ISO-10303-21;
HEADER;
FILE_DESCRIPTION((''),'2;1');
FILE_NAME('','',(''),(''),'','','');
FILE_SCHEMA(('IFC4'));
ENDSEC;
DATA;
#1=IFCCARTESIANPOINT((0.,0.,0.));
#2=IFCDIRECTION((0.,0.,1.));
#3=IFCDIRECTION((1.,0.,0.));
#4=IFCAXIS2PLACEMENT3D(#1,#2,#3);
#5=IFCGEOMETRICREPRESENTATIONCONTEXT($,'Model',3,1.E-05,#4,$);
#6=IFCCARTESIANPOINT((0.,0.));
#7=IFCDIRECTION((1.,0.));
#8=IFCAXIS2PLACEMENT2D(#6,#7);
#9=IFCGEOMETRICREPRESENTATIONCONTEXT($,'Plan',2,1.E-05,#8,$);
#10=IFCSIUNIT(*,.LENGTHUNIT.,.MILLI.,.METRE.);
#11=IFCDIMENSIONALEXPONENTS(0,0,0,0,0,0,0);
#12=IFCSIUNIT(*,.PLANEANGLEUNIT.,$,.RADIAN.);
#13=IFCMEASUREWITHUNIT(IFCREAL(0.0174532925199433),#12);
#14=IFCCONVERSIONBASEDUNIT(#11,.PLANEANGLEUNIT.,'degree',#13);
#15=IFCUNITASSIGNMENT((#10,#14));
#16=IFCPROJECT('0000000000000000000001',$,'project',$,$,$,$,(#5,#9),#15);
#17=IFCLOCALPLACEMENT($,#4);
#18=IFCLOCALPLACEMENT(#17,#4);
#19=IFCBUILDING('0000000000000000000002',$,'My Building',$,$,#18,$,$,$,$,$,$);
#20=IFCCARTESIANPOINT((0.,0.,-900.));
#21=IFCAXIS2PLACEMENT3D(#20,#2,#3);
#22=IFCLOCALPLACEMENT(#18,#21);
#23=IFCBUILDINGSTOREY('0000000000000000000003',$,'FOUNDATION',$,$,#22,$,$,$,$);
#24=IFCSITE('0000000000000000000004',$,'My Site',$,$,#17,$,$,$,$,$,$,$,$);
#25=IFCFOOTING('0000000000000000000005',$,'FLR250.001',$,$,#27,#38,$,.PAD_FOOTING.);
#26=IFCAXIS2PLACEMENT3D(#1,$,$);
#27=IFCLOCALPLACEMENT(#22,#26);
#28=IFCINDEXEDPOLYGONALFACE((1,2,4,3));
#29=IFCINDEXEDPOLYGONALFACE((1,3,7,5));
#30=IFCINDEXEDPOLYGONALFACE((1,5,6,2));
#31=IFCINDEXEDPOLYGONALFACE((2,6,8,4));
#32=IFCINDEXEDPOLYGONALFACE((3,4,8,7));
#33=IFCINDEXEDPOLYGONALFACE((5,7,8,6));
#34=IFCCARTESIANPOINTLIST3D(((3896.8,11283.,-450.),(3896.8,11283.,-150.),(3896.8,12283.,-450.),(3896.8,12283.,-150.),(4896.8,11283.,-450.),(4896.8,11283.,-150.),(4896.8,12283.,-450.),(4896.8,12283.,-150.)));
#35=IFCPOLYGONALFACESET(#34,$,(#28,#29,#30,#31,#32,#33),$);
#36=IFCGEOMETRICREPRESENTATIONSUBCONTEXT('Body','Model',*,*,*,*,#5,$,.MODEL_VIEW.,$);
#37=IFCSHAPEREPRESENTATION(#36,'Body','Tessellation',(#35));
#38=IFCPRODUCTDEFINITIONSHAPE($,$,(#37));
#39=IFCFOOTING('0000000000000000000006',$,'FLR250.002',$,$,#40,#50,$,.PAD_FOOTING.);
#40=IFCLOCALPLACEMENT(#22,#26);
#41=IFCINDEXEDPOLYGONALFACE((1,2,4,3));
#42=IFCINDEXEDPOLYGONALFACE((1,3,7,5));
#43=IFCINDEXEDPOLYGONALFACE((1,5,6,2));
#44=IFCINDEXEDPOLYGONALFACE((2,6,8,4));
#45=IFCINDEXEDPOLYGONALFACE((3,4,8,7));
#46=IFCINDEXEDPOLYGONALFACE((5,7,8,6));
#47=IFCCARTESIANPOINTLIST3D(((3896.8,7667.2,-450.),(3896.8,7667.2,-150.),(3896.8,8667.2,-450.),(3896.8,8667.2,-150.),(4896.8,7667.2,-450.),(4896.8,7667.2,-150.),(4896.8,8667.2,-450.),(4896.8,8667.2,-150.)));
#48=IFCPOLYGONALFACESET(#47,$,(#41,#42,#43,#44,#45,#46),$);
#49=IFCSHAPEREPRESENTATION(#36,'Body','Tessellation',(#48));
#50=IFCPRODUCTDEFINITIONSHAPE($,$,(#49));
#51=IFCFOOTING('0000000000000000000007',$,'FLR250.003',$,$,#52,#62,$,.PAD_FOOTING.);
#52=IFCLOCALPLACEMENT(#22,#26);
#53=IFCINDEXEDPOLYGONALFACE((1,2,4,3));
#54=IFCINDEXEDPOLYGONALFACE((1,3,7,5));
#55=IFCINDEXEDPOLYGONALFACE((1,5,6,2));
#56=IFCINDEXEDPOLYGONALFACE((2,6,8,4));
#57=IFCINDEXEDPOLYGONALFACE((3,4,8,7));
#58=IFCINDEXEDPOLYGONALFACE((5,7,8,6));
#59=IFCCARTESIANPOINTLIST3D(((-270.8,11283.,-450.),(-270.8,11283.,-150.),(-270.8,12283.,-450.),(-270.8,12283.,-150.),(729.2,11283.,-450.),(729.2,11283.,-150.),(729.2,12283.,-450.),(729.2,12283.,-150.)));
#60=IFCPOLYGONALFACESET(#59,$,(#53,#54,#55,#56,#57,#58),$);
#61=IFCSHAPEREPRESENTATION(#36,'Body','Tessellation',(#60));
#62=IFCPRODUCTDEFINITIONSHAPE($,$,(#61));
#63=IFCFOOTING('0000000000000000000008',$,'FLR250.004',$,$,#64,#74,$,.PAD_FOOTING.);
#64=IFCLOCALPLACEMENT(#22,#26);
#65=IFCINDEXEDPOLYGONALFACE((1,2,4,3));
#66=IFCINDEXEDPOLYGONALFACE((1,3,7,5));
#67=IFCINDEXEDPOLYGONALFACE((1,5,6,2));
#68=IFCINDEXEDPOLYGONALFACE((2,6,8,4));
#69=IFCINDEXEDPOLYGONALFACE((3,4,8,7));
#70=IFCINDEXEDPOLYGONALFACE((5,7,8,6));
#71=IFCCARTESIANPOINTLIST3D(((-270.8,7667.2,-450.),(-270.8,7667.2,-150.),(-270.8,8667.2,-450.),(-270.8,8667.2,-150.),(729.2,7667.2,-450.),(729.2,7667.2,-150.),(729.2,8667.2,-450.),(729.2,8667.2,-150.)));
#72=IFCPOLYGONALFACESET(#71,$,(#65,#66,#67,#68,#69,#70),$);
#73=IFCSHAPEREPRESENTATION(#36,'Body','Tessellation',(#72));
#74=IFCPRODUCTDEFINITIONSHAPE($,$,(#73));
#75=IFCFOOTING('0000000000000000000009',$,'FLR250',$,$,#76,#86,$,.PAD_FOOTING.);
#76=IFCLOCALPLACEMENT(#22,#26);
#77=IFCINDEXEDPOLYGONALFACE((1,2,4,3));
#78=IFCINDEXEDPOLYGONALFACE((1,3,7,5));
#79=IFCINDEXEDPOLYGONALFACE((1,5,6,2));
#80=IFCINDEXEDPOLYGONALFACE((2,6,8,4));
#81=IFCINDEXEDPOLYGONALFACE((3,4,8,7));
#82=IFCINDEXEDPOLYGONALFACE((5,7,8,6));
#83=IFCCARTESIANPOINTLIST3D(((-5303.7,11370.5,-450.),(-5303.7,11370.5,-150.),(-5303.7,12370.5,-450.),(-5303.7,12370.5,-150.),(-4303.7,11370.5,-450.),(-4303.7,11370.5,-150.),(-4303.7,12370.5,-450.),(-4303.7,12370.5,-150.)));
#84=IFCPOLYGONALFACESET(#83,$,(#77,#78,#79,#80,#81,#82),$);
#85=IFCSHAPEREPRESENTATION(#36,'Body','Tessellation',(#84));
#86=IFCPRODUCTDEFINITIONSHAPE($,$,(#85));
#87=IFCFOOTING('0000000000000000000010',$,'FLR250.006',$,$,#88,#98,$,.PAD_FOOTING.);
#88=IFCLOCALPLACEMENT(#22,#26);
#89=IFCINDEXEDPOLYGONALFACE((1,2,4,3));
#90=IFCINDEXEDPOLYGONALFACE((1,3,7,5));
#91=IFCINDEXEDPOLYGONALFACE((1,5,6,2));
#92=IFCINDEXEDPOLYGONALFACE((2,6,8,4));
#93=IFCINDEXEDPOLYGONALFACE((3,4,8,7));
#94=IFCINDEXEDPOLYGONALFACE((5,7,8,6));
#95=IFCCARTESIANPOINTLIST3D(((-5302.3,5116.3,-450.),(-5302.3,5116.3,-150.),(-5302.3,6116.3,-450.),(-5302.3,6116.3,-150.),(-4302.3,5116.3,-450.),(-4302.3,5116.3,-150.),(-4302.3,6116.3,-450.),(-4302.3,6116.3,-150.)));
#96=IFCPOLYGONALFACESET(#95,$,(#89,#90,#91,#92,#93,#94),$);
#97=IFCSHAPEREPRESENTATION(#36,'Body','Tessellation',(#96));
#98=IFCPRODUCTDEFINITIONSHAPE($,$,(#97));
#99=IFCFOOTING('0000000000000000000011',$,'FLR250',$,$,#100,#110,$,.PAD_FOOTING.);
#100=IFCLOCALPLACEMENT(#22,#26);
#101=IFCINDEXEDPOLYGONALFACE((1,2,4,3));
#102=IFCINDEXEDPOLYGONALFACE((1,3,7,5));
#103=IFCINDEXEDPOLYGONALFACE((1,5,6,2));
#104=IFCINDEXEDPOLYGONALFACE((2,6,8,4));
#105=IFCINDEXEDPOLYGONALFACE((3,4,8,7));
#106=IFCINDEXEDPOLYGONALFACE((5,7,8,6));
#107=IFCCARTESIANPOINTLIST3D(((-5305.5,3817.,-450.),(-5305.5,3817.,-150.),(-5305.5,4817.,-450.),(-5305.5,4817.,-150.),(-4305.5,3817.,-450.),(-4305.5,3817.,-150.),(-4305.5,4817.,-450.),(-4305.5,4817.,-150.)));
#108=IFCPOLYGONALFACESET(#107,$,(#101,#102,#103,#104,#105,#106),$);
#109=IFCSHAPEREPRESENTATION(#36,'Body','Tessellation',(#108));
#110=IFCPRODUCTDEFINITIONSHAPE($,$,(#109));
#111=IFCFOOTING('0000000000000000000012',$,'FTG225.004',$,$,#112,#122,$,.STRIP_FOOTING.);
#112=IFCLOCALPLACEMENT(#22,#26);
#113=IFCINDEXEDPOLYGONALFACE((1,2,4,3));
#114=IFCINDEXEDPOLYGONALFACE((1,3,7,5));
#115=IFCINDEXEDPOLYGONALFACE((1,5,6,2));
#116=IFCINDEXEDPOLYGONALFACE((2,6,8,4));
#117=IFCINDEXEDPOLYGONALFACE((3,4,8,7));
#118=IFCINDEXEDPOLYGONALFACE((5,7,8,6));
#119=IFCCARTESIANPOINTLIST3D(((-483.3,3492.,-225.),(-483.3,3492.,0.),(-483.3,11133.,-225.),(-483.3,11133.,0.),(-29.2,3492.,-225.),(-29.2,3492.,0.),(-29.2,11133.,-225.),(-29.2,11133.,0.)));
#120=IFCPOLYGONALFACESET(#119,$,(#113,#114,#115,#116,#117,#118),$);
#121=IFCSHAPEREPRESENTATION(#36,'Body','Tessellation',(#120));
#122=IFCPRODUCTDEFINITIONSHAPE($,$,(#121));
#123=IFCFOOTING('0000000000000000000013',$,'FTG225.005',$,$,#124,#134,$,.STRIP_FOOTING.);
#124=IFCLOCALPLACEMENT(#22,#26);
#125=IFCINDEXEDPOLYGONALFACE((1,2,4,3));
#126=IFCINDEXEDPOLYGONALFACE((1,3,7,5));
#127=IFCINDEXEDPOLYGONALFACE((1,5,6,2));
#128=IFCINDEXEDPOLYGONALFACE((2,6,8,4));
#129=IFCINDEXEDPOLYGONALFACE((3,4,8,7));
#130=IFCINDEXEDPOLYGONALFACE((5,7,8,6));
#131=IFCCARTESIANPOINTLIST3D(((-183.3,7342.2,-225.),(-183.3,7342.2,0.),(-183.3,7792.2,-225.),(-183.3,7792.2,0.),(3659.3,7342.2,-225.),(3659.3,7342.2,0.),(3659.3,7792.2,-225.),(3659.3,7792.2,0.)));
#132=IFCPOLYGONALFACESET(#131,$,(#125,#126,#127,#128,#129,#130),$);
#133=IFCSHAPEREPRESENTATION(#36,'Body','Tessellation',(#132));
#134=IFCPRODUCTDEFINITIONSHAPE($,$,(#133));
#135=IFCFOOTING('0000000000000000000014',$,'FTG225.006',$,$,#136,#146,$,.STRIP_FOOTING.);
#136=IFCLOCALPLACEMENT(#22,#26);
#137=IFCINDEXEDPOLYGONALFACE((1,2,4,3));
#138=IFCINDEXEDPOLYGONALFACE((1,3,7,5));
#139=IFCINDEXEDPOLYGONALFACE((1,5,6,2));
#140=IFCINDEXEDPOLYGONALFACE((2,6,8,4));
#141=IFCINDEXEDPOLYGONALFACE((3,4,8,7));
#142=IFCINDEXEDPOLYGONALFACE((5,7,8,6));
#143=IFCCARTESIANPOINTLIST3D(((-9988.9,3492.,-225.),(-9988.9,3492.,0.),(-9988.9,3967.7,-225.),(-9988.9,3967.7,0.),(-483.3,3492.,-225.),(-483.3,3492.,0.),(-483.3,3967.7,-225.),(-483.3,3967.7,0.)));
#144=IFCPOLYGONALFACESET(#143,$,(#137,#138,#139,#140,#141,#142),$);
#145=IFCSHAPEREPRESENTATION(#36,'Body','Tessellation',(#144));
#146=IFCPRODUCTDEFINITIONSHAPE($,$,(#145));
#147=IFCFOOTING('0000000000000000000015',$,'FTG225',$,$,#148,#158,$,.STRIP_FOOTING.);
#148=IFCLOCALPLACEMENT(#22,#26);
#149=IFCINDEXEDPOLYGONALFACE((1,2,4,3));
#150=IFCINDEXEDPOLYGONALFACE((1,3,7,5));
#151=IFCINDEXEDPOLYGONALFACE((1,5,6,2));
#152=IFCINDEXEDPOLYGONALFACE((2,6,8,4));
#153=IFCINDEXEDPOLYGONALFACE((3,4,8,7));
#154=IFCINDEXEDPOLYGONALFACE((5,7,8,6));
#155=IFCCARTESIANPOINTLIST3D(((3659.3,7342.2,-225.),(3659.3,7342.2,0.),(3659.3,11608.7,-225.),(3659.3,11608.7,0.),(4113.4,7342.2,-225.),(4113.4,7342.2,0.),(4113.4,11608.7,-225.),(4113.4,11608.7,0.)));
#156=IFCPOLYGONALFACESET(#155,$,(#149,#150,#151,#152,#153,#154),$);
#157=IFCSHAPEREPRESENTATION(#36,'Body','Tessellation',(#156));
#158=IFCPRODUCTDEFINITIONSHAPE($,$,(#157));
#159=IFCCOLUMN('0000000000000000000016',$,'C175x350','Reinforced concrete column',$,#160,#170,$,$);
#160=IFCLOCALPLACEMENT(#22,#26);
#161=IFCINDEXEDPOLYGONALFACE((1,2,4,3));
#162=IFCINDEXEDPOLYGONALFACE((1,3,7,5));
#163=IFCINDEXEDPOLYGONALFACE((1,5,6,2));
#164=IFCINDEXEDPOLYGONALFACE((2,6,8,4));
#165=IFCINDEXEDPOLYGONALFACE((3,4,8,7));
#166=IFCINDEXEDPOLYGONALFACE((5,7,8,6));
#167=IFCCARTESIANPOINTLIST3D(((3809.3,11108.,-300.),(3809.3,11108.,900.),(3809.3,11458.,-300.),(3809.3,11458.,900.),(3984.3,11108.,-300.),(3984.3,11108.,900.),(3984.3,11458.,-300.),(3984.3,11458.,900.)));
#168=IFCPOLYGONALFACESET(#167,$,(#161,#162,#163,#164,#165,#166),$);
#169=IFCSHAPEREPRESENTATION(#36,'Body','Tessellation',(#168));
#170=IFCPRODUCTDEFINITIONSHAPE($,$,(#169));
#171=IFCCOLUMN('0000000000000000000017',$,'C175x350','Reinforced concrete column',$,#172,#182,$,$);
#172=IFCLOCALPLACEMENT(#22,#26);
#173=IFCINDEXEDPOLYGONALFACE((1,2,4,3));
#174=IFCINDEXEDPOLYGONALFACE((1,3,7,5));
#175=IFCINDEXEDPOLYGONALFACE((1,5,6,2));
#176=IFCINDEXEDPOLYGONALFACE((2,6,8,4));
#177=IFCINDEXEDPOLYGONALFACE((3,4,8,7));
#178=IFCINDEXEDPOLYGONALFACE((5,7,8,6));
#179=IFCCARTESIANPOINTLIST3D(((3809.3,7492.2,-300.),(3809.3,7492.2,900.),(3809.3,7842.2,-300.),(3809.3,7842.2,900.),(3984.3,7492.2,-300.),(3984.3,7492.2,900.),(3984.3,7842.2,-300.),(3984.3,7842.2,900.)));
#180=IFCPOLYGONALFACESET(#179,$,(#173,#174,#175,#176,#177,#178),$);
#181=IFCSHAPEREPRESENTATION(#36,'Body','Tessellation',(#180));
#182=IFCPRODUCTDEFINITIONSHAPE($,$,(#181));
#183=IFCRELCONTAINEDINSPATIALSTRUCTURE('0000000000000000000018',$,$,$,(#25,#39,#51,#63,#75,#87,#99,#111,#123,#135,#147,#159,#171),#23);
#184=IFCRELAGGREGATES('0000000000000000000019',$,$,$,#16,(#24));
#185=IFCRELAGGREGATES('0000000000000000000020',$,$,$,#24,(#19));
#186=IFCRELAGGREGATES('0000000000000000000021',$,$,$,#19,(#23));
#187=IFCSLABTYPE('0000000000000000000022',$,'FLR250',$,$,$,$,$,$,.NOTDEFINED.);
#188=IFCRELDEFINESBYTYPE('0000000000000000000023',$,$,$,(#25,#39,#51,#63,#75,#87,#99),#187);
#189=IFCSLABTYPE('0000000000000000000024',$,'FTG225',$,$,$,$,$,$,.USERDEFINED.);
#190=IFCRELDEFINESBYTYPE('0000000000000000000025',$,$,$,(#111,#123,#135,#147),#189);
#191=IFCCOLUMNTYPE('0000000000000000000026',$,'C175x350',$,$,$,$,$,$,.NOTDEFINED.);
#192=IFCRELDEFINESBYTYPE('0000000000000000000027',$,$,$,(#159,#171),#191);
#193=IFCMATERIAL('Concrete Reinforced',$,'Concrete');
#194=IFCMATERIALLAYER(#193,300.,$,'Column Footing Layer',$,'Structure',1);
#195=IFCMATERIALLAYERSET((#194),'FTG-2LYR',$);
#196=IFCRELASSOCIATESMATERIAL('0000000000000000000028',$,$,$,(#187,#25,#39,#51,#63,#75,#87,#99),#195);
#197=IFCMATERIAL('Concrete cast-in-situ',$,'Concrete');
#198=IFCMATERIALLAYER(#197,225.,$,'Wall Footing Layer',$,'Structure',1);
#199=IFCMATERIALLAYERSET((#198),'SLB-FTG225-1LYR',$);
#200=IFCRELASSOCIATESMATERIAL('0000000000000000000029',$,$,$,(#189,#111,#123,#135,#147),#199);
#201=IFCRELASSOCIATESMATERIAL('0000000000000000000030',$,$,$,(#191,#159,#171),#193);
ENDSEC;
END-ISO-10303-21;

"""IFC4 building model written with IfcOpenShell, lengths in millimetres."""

from ifc_helpers import new_model, entity, si_unit, converted_unit, frame, origin_with_axes, origin_2d_with_axis, place, context, subcontext, project, spatial, line, indexed_curve, rectangle, outline, extrude, material, layer, layer_set, layer_usage, material_profile, profile_set, profile_usage, type_object, element, save


model = new_model("IFC4")

# Units and contexts
model_context = context("Model", 3, precision=1e-05, world=origin_with_axes())
plan_context = context("Plan", 2, precision=1e-05, world=origin_2d_with_axis())
body_context = subcontext(model_context, "Body", "Model", "MODEL_VIEW")
ifc_project = project(units=[si_unit("LENGTHUNIT", "METRE", prefix="MILLI"), converted_unit("PLANEANGLEUNIT", "degree", entity("IfcReal", 0.0174532925199433), si_unit("PLANEANGLEUNIT", "RADIAN"), dimensions=[0, 0, 0, 0, 0, 0, 0])], contexts=[model_context, plan_context])

# Site, building, storey
site_placement = place(None, origin_with_axes())
site = spatial("IfcSite", under=ifc_project, at=site_placement, Name="My Site")
building_placement = place(site_placement, origin_with_axes())
building = spatial("IfcBuilding", under=site, at=building_placement, Name="My Building")
storey_placement = place(building_placement, frame((0.0, 0.0, -900.0), z_axis=(0.0, 0.0, 1.0), x_axis=(1.0, 0.0, 0.0)))
storey = spatial("IfcBuildingStorey", under=building, at=storey_placement, Name="FOUNDATION")

# Footings
ifc_material_1 = material(Name="Concrete Reinforced", Category="Concrete")
ifc_layer_1 = layer(ifc_material_1, 300.0, Name="Column Footing Layer", Category="Structure", Priority=1)
ifc_layer_set_1 = layer_set([ifc_layer_1], Name="FTG-2LYR")
ifc_layer_usage_1 = layer_usage(ifc_layer_set_1, "AXIS3", "POSITIVE", 0.0)
slab_type_1 = type_object("IfcSlabType", Name="FLR250", PredefinedType="NOTDEFINED", material=ifc_layer_set_1)
footing_1_placement = place(storey_placement, frame((3896.8, 11283.0, -450.0), z_axis=(0.0, 0.0, 1.0), x_axis=(1.0, 0.0, 0.0)))
element("IfcFooting", 1, at=footing_1_placement, inside=storey, type_object=slab_type_1, material=ifc_layer_usage_1, Name="FLR250.001", PredefinedType="PAD_FOOTING", context=body_context, shape_type="SweptSolid", body=[
    extrude(outline(indexed_curve([(0.0, 0.0), (1000.0, 0.0), (1000.0, 1000.0), (0.0, 1000.0), (0.0, 0.0)])), None, (0.0, 0.0, 1.0), 300.0),
])
ifc_layer_usage_2 = layer_usage(ifc_layer_set_1, "AXIS3", "POSITIVE", 0.0)
footing_2_placement = place(storey_placement, frame((3896.8, 7667.2, -450.0), z_axis=(0.0, 0.0, 1.0), x_axis=(1.0, 0.0, 0.0)))
element("IfcFooting", 2, at=footing_2_placement, inside=storey, type_object=slab_type_1, material=ifc_layer_usage_2, Name="FLR250.002", PredefinedType="PAD_FOOTING", context=body_context, shape_type="SweptSolid", body=[
    extrude(outline(indexed_curve([(0.0, 0.0), (1000.0, 0.0), (1000.0, 1000.0), (0.0, 1000.0), (0.0, 0.0)])), None, (0.0, 0.0, 1.0), 300.0),
])
ifc_layer_usage_3 = layer_usage(ifc_layer_set_1, "AXIS3", "POSITIVE", 0.0)
footing_3_placement = place(storey_placement, frame((-270.8, 11283.0, -450.0), z_axis=(0.0, 0.0, 1.0), x_axis=(1.0, 0.0, 0.0)))
element("IfcFooting", 3, at=footing_3_placement, inside=storey, type_object=slab_type_1, material=ifc_layer_usage_3, Name="FLR250.003", PredefinedType="PAD_FOOTING", context=body_context, shape_type="SweptSolid", body=[
    extrude(outline(indexed_curve([(0.0, 0.0), (1000.0, 0.0), (1000.0, 1000.0), (0.0, 1000.0), (0.0, 0.0)])), None, (0.0, 0.0, 1.0), 300.0),
])
ifc_layer_usage_4 = layer_usage(ifc_layer_set_1, "AXIS3", "POSITIVE", 0.0)
footing_4_placement = place(storey_placement, frame((-270.8, 7667.2, -450.0), z_axis=(0.0, 0.0, 1.0), x_axis=(1.0, 0.0, 0.0)))
element("IfcFooting", 4, at=footing_4_placement, inside=storey, type_object=slab_type_1, material=ifc_layer_usage_4, Name="FLR250.004", PredefinedType="PAD_FOOTING", context=body_context, shape_type="SweptSolid", body=[
    extrude(outline(indexed_curve([(0.0, 0.0), (1000.0, 0.0), (1000.0, 1000.0), (0.0, 1000.0), (0.0, 0.0)])), None, (0.0, 0.0, 1.0), 300.0),
])
ifc_layer_usage_5 = layer_usage(ifc_layer_set_1, "AXIS3", "POSITIVE", 0.0)
footing_5_placement = place(storey_placement, frame((-5303.7, 11370.5, -450.0), z_axis=(0.0, 0.0, 1.0), x_axis=(1.0, 0.0, 0.0)))
element("IfcFooting", 5, at=footing_5_placement, inside=storey, type_object=slab_type_1, material=ifc_layer_usage_5, Name="FLR250", PredefinedType="PAD_FOOTING", context=body_context, shape_type="SweptSolid", body=[
    extrude(outline(indexed_curve([(0.0, 0.0), (1000.0, 0.0), (1000.0, 1000.0), (0.0, 1000.0), (0.0, 0.0)])), None, (0.0, 0.0, 1.0), 300.0),
])
ifc_layer_usage_6 = layer_usage(ifc_layer_set_1, "AXIS3", "POSITIVE", 0.0)
footing_6_placement = place(storey_placement, frame((-5302.3, 5116.3, -450.0), z_axis=(0.0, 0.0, 1.0), x_axis=(1.0, 0.0, 0.0)))
element("IfcFooting", 6, at=footing_6_placement, inside=storey, type_object=slab_type_1, material=ifc_layer_usage_6, Name="FLR250.006", PredefinedType="PAD_FOOTING", context=body_context, shape_type="SweptSolid", body=[
    extrude(outline(indexed_curve([(0.0, 0.0), (1000.0, 0.0), (1000.0, 1000.0), (0.0, 1000.0), (0.0, 0.0)])), None, (0.0, 0.0, 1.0), 300.0),
])
ifc_layer_usage_7 = layer_usage(ifc_layer_set_1, "AXIS3", "POSITIVE", 0.0)
footing_7_placement = place(storey_placement, frame((-5305.5, 3817.0, -450.0), z_axis=(0.0, 0.0, 1.0), x_axis=(1.0, 0.0, 0.0)))
element("IfcFooting", 7, at=footing_7_placement, inside=storey, type_object=slab_type_1, material=ifc_layer_usage_7, Name="FLR250", PredefinedType="PAD_FOOTING", context=body_context, shape_type="SweptSolid", body=[
    extrude(outline(indexed_curve([(0.0, 0.0), (1000.0, 0.0), (1000.0, 1000.0), (0.0, 1000.0), (0.0, 0.0)])), None, (0.0, 0.0, 1.0), 300.0),
])
ifc_material_2 = material(Name="Concrete cast-in-situ", Category="Concrete")
ifc_layer_2 = layer(ifc_material_2, 225.0, Name="Wall Footing Layer", Category="Structure", Priority=1)
ifc_layer_set_2 = layer_set([ifc_layer_2], Name="SLB-FTG225-1LYR")
slab_type_2 = type_object("IfcSlabType", Name="FTG225", PredefinedType="USERDEFINED", material=ifc_layer_set_2)
ifc_layer_usage_8 = layer_usage(ifc_layer_set_2, "AXIS3", "POSITIVE", 0.0)
footing_8_placement = place(storey_placement, frame((-483.3, 3492.0, -225.0), z_axis=(0.0, 0.0, 1.0), x_axis=(1.0, 0.0, 0.0)))
element("IfcFooting", 8, at=footing_8_placement, inside=storey, type_object=slab_type_2, material=ifc_layer_usage_8, Name="FTG225.004", PredefinedType="STRIP_FOOTING", context=body_context, shape_type="SweptSolid", body=[
    extrude(outline(indexed_curve([(454.1, 7641.0), (454.1, 0.0), (0.0, 0.0), (0.0, 7641.0)], segments=[line(3, 2), line(2, 1), line(1, 4), line(4, 3)], self_intersect=False)), None, (0.0, 0.0, 1.0), 225.0),
])
ifc_layer_usage_9 = layer_usage(ifc_layer_set_2, "AXIS3", "POSITIVE", 0.0)
footing_9_placement = place(storey_placement, frame((-183.3, 7342.2, -225.0), z_axis=(0.0, 0.0, 1.0), x_axis=(1.0, 0.0, 0.0)))
element("IfcFooting", 9, at=footing_9_placement, inside=storey, type_object=slab_type_2, material=ifc_layer_usage_9, Name="FTG225.005", PredefinedType="STRIP_FOOTING", context=body_context, shape_type="SweptSolid", body=[
    extrude(outline(indexed_curve([(3842.6, 450.0), (3842.6, 0.0), (0.0, 0.0), (0.0, 450.0)], segments=[line(3, 2), line(2, 1), line(1, 4), line(4, 3)], self_intersect=False)), None, (0.0, 0.0, 1.0), 225.0),
])
ifc_layer_usage_10 = layer_usage(ifc_layer_set_2, "AXIS3", "POSITIVE", 0.0)
footing_10_placement = place(storey_placement, frame((-9988.9, 3492.0, -225.0), z_axis=(0.0, 0.0, 1.0), x_axis=(1.0, 0.0, 0.0)))
element("IfcFooting", 10, at=footing_10_placement, inside=storey, type_object=slab_type_2, material=ifc_layer_usage_10, Name="FTG225.006", PredefinedType="STRIP_FOOTING", context=body_context, shape_type="SweptSolid", body=[
    extrude(outline(indexed_curve([(9505.7, 475.7), (9505.7, 0.0), (0.0, 0.0), (0.0, 475.7)], segments=[line(3, 2), line(2, 1), line(1, 4), line(4, 3)], self_intersect=False)), None, (0.0, 0.0, 1.0), 225.0),
])
ifc_layer_usage_11 = layer_usage(ifc_layer_set_2, "AXIS3", "POSITIVE", 0.0)
footing_11_placement = place(storey_placement, frame((3659.3, 7342.2, -225.0), z_axis=(0.0, 0.0, 1.0), x_axis=(1.0, 0.0, 0.0)))
element("IfcFooting", 11, at=footing_11_placement, inside=storey, type_object=slab_type_2, material=ifc_layer_usage_11, Name="FTG225", PredefinedType="STRIP_FOOTING", context=body_context, shape_type="SweptSolid", body=[
    extrude(outline(indexed_curve([(0.0, 0.0), (454.1, 0.0), (454.1, 4266.5), (0.0, 4266.5)], segments=[line(3, 2), line(2, 1), line(1, 4), line(4, 3)], self_intersect=False)), None, (0.0, 0.0, 1.0), 225.0),
])

# Columns
ifc_material_profile = material_profile(ifc_material_1, rectangle(XDim=175.0, YDim=350.0), Name="R. C. Layer", Category="Structure", Priority=1)
ifc_profile_set = profile_set([ifc_material_profile], Name="COL_1LYR")
ifc_profile_usage_1 = profile_usage(ifc_profile_set, cardinal=5)
column_type = type_object("IfcColumnType", Name="C175x350", PredefinedType="NOTDEFINED", material=ifc_profile_set)
column_1_placement = place(storey_placement, frame((3896.8, 11283.0, -300.0), z_axis=(0.0, 0.0, 1.0), x_axis=(1.0, 0.0, 0.0)))
element("IfcColumn", 12, at=column_1_placement, inside=storey, type_object=column_type, material=ifc_profile_usage_1, Name="C175x350", Description="Reinforced concrete column", context=body_context, shape_type="SweptSolid", body=[
    extrude(rectangle(XDim=175.0, YDim=350.0), origin_with_axes(), (0.0, 0.0, 1.0), 1200.0),
])
ifc_profile_usage_2 = profile_usage(ifc_profile_set, cardinal=5)
column_2_placement = place(storey_placement, frame((3896.8, 7667.2, -300.0), z_axis=(0.0, 0.0, 1.0), x_axis=(1.0, 0.0, 0.0)))
element("IfcColumn", 13, at=column_2_placement, inside=storey, type_object=column_type, material=ifc_profile_usage_2, Name="C175x350", Description="Reinforced concrete column", context=body_context, shape_type="SweptSolid", body=[
    extrude(rectangle(XDim=175.0, YDim=350.0), origin_with_axes(), (0.0, 0.0, 1.0), 1200.0),
])

save(model, "model.ifc")
